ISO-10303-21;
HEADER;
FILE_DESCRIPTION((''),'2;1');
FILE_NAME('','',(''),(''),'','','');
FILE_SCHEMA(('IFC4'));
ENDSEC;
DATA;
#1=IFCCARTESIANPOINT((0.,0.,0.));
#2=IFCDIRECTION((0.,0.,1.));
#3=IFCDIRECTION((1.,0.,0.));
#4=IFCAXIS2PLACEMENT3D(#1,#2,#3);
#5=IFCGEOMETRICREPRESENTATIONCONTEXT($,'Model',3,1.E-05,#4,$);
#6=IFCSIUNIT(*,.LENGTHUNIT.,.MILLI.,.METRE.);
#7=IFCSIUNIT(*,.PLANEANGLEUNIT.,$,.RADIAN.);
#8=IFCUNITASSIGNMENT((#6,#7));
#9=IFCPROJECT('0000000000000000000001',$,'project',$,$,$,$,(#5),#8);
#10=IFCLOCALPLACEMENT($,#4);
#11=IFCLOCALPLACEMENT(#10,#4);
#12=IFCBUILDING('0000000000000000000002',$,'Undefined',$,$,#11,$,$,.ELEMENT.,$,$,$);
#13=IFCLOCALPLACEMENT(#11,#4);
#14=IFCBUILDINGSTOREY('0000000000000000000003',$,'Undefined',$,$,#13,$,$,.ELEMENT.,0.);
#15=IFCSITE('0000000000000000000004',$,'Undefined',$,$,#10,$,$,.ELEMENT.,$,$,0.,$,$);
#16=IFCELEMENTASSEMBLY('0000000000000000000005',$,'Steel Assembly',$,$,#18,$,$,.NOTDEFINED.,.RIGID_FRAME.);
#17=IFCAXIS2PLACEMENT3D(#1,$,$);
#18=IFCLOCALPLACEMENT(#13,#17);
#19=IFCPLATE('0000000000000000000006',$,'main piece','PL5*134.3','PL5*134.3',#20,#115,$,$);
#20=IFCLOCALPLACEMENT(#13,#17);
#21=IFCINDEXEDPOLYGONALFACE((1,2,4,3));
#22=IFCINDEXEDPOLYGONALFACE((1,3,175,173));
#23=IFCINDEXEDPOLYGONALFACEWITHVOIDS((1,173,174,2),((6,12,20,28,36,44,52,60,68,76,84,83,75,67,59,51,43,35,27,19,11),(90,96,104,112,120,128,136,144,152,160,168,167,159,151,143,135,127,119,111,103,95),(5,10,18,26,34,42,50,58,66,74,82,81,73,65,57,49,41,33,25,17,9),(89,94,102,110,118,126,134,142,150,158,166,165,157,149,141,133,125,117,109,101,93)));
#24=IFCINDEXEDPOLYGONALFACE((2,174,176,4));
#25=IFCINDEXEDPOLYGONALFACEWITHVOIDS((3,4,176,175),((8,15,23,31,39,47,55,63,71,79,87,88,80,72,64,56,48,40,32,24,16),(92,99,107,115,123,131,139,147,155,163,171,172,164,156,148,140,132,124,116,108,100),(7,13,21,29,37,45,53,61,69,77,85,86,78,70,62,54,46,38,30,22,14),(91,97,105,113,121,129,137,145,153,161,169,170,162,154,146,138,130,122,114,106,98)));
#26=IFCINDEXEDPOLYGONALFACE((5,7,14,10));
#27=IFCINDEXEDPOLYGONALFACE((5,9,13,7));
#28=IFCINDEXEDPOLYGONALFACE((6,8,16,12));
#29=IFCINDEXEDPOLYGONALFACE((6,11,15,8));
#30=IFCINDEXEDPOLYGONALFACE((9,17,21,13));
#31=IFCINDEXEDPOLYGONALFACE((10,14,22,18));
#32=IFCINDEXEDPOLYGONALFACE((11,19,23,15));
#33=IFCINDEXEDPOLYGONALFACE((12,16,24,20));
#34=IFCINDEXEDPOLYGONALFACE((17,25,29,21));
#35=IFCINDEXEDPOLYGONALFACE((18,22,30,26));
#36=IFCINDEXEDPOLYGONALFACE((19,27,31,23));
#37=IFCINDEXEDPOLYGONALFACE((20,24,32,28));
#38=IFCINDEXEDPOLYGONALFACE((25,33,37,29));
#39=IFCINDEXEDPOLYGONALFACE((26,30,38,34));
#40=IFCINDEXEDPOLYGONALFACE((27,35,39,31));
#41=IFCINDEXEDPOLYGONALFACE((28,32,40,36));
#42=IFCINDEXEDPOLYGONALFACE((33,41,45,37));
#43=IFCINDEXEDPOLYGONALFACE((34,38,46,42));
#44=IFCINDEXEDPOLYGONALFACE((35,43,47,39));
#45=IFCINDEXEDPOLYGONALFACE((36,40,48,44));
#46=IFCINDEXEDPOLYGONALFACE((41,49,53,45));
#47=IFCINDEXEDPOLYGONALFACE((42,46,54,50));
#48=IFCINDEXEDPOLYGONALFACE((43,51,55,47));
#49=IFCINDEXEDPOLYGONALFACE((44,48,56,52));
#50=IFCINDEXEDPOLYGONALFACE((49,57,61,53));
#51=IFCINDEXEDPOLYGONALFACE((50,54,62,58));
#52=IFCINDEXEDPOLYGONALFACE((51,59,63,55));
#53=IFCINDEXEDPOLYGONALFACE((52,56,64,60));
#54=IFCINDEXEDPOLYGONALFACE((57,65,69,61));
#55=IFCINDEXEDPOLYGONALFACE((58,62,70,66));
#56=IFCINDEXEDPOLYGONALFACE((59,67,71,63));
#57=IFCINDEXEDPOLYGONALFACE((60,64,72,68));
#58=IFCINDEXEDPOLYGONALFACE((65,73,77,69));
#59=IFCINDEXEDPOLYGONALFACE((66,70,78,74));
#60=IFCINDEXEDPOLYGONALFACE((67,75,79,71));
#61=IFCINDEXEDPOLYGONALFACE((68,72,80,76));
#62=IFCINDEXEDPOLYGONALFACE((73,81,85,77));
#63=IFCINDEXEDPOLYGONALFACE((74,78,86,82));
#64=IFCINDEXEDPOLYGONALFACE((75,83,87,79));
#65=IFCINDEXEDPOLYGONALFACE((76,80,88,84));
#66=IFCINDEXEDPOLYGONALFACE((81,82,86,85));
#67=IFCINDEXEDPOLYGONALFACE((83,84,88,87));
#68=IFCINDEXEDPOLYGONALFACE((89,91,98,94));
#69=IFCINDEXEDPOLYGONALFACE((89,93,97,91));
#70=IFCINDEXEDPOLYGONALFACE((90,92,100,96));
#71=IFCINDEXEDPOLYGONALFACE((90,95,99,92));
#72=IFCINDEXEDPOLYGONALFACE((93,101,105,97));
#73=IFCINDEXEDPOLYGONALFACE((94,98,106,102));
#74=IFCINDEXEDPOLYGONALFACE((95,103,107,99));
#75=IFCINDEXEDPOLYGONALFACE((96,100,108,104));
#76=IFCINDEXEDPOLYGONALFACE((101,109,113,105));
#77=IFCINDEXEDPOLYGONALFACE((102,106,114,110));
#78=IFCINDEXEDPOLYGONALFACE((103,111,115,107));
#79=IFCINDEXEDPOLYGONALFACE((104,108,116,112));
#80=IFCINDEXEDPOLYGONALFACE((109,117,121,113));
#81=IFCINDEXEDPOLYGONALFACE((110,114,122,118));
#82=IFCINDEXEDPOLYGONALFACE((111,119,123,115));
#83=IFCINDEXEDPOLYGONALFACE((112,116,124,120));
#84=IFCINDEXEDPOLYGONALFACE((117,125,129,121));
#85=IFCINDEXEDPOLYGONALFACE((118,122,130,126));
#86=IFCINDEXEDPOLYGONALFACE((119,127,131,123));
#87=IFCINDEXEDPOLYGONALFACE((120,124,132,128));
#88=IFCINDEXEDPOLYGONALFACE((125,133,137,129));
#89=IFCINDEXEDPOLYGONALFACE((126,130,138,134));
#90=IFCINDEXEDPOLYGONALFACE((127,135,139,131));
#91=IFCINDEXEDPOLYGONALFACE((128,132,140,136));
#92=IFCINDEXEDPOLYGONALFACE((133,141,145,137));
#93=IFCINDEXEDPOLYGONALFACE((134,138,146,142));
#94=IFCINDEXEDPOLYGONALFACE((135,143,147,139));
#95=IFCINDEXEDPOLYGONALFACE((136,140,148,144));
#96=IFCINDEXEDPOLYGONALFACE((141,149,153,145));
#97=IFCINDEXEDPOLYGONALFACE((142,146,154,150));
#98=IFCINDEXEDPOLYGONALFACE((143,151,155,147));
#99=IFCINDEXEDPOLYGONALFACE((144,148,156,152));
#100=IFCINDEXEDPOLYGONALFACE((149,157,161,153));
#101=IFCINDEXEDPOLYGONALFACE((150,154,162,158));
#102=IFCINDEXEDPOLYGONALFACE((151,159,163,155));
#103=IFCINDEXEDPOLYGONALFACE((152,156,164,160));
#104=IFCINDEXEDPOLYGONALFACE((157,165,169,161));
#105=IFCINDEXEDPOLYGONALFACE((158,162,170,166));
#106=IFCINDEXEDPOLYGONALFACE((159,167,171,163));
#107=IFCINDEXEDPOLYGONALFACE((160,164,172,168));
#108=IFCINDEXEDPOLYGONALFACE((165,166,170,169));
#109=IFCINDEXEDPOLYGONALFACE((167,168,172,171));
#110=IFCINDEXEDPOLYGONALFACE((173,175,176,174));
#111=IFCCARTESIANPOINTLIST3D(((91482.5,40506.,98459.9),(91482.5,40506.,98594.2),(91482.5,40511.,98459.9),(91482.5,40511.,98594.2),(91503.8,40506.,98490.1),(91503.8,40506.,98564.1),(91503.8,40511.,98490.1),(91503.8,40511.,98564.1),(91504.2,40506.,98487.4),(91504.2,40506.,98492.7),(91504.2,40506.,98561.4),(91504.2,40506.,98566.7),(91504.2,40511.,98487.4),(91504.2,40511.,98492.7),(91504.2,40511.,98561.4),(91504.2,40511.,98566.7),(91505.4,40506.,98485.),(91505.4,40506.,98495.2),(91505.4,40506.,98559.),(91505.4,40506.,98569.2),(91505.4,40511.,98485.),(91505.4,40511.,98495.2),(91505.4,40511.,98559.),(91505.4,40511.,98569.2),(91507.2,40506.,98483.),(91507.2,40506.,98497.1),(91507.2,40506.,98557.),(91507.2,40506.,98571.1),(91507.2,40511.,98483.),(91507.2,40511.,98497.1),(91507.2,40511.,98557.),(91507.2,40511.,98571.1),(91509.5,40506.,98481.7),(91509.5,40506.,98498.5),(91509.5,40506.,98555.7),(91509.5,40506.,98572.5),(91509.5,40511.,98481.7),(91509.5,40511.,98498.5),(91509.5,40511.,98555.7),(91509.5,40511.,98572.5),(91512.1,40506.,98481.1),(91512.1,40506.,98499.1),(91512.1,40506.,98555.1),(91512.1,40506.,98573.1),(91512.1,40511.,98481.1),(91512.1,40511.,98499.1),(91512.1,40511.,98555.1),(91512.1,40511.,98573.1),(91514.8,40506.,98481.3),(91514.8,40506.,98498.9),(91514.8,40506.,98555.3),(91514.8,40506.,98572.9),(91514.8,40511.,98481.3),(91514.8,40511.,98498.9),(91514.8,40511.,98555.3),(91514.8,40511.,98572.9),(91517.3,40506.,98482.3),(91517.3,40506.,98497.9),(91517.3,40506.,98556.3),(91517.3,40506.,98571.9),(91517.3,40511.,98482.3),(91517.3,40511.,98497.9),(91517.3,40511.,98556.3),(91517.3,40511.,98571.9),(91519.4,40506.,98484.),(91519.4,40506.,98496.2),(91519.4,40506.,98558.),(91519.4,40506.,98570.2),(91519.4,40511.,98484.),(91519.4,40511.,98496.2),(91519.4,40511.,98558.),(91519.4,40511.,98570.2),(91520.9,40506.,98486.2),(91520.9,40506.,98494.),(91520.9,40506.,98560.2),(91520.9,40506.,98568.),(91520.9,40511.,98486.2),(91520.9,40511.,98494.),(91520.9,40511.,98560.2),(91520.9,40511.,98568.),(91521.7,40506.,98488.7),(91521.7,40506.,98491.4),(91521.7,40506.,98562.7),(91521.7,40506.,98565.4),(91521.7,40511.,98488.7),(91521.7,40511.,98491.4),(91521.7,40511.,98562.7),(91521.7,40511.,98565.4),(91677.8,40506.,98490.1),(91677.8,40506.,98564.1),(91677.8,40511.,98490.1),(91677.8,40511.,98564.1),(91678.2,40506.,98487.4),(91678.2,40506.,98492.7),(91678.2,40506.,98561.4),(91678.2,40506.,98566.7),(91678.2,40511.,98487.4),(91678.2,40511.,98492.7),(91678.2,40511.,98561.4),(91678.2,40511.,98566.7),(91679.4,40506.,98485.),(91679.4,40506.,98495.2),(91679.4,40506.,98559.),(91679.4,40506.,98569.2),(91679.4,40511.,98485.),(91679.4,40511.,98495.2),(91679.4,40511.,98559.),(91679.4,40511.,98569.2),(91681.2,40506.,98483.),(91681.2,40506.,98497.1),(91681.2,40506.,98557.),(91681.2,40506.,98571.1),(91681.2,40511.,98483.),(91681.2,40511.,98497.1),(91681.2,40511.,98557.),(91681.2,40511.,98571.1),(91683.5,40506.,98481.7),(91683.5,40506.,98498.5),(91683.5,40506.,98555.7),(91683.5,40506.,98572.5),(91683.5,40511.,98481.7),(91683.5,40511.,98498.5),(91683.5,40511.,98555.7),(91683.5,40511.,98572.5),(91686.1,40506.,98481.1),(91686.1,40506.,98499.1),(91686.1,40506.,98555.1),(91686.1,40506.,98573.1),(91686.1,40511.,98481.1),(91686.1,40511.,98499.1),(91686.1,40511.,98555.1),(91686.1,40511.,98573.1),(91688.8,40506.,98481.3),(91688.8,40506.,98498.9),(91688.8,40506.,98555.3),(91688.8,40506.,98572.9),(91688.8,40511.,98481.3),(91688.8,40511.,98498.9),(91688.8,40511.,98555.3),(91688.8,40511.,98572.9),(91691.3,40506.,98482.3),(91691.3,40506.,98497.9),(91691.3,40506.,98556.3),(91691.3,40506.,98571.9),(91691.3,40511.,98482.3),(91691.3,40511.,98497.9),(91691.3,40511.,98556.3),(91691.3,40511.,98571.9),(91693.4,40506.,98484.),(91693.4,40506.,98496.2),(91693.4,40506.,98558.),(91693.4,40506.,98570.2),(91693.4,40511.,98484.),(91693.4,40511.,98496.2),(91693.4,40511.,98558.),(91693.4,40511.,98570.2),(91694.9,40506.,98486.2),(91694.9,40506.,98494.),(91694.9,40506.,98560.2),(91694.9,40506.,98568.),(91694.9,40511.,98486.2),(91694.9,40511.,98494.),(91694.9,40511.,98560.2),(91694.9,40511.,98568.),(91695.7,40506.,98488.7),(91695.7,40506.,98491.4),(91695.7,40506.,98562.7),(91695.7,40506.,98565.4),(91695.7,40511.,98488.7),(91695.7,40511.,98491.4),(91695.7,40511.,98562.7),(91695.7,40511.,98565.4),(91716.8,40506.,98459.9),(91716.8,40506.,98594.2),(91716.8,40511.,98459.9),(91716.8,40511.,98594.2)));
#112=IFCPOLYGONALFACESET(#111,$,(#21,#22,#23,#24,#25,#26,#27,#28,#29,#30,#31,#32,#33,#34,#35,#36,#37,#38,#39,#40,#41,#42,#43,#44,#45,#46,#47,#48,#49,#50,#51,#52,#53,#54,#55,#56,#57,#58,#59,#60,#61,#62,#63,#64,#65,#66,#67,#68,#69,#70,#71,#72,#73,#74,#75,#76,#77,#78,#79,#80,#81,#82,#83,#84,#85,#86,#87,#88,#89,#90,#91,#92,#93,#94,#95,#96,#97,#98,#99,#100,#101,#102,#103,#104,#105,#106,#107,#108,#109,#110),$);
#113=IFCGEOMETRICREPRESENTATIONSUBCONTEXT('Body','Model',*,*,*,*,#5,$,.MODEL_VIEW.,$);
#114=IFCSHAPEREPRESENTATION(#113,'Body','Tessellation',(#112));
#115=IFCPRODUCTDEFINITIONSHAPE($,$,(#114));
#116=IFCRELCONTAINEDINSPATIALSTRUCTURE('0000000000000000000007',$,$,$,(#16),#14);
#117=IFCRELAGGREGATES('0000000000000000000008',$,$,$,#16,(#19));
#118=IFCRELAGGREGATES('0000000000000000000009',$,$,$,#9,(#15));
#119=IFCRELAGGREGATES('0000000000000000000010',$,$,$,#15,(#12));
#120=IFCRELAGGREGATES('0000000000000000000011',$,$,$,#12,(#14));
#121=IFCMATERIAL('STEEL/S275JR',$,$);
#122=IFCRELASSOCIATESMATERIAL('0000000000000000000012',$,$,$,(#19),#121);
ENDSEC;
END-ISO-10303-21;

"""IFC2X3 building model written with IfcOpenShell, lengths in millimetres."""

from ifc_helpers import new_model, si_unit, frame, origin_with_axes, origin_2d_with_axis, place, context, subcontext, project, spatial, polyline, circle, outline, extrude, source, transform, mapped, material, element, aggregate, save


model = new_model("IFC2X3")

# Units and contexts
model_context = context("Model", 3, precision=1e-05, world=origin_with_axes())
body_context = subcontext(model_context, "Body", "Model", "MODEL_VIEW")
ifc_project = project(units=[si_unit("LENGTHUNIT", "METRE", prefix="MILLI"), si_unit("PLANEANGLEUNIT", "RADIAN")], contexts=[model_context])

# Site, building, storey
site_placement = place(None, origin_with_axes())
site = spatial("IfcSite", under=ifc_project, at=site_placement, Name="Undefined", CompositionType="ELEMENT", RefElevation=0.0)
building_placement = place(site_placement, origin_with_axes())
building = spatial("IfcBuilding", under=site, at=building_placement, Name="Undefined", CompositionType="ELEMENT")
storey_placement = place(building_placement, origin_with_axes())
storey = spatial("IfcBuildingStorey", under=building, at=storey_placement, Name="Undefined", CompositionType="ELEMENT", Elevation=0.0)

# Element assembly, plate, opening
assembly_1_placement = place(storey_placement, origin_with_axes())
assembly_1 = element("IfcElementAssembly", 1, at=assembly_1_placement, inside=storey, Name="Steel Assembly", AssemblyPlace="NOTDEFINED", PredefinedType="RIGID_FRAME")
ifc_material_1 = material(Name="STEEL/S275JR")
plate_1_placement = place(assembly_1_placement, frame((91716.8, 40508.5, 98594.2), z_axis=(0.0, 1.0, 0.0), x_axis=(0.0, 0.0, -1.0)))
plate_1 = element("IfcPlate", 2, at=plate_1_placement, material=ifc_material_1, Name="main piece", Description="PL5*134.3", ObjectType="PL5*134.3", context=body_context, shape_type="SweptSolid", body=[
    extrude(outline(polyline([(0.0, 0.0), (134.3, 0.0), (134.3, 234.3), (0.0, 234.3), (0.0, 0.0)])), frame((0.0, 0.0, -2.5), z_axis=(0.0, 0.0, 1.0), x_axis=(1.0, 0.0, 0.0)), (0.0, 0.0, 1.0), 5.0),
])
shared_shape_1 = source(origin_with_axes(), body_context, "Body", "SweptSolid", [
    extrude(circle(Radius=9.0, at=origin_2d_with_axis()), frame((0.0, -35.1, 0.0), z_axis=(0.0, 1.0, 0.0), x_axis=(1.0, 0.0, 0.0)), (0.0, 0.0, 1.0), 40.3),
])
opening_1_placement = place(assembly_1_placement, frame((91686.8, 40476.0, 98527.1), z_axis=(0.0, 0.0, 1.0), x_axis=(-1.0, 0.0, 0.0)))
element("IfcOpeningElement", 3, at=opening_1_placement, cuts=plate_1, ObjectType="Opening", context=body_context, shape_type="MappedRepresentation", body=[
    mapped(shared_shape_1, transform((0.0, 0.0, -37.0))),
    mapped(shared_shape_1, transform((174.0, 0.0, -37.0))),
    mapped(shared_shape_1, transform((0.0, 0.0, 37.0))),
    mapped(shared_shape_1, transform((174.0, 0.0, 37.0))),
])
aggregate(assembly_1, [plate_1])

save(model, "model.ifc")
